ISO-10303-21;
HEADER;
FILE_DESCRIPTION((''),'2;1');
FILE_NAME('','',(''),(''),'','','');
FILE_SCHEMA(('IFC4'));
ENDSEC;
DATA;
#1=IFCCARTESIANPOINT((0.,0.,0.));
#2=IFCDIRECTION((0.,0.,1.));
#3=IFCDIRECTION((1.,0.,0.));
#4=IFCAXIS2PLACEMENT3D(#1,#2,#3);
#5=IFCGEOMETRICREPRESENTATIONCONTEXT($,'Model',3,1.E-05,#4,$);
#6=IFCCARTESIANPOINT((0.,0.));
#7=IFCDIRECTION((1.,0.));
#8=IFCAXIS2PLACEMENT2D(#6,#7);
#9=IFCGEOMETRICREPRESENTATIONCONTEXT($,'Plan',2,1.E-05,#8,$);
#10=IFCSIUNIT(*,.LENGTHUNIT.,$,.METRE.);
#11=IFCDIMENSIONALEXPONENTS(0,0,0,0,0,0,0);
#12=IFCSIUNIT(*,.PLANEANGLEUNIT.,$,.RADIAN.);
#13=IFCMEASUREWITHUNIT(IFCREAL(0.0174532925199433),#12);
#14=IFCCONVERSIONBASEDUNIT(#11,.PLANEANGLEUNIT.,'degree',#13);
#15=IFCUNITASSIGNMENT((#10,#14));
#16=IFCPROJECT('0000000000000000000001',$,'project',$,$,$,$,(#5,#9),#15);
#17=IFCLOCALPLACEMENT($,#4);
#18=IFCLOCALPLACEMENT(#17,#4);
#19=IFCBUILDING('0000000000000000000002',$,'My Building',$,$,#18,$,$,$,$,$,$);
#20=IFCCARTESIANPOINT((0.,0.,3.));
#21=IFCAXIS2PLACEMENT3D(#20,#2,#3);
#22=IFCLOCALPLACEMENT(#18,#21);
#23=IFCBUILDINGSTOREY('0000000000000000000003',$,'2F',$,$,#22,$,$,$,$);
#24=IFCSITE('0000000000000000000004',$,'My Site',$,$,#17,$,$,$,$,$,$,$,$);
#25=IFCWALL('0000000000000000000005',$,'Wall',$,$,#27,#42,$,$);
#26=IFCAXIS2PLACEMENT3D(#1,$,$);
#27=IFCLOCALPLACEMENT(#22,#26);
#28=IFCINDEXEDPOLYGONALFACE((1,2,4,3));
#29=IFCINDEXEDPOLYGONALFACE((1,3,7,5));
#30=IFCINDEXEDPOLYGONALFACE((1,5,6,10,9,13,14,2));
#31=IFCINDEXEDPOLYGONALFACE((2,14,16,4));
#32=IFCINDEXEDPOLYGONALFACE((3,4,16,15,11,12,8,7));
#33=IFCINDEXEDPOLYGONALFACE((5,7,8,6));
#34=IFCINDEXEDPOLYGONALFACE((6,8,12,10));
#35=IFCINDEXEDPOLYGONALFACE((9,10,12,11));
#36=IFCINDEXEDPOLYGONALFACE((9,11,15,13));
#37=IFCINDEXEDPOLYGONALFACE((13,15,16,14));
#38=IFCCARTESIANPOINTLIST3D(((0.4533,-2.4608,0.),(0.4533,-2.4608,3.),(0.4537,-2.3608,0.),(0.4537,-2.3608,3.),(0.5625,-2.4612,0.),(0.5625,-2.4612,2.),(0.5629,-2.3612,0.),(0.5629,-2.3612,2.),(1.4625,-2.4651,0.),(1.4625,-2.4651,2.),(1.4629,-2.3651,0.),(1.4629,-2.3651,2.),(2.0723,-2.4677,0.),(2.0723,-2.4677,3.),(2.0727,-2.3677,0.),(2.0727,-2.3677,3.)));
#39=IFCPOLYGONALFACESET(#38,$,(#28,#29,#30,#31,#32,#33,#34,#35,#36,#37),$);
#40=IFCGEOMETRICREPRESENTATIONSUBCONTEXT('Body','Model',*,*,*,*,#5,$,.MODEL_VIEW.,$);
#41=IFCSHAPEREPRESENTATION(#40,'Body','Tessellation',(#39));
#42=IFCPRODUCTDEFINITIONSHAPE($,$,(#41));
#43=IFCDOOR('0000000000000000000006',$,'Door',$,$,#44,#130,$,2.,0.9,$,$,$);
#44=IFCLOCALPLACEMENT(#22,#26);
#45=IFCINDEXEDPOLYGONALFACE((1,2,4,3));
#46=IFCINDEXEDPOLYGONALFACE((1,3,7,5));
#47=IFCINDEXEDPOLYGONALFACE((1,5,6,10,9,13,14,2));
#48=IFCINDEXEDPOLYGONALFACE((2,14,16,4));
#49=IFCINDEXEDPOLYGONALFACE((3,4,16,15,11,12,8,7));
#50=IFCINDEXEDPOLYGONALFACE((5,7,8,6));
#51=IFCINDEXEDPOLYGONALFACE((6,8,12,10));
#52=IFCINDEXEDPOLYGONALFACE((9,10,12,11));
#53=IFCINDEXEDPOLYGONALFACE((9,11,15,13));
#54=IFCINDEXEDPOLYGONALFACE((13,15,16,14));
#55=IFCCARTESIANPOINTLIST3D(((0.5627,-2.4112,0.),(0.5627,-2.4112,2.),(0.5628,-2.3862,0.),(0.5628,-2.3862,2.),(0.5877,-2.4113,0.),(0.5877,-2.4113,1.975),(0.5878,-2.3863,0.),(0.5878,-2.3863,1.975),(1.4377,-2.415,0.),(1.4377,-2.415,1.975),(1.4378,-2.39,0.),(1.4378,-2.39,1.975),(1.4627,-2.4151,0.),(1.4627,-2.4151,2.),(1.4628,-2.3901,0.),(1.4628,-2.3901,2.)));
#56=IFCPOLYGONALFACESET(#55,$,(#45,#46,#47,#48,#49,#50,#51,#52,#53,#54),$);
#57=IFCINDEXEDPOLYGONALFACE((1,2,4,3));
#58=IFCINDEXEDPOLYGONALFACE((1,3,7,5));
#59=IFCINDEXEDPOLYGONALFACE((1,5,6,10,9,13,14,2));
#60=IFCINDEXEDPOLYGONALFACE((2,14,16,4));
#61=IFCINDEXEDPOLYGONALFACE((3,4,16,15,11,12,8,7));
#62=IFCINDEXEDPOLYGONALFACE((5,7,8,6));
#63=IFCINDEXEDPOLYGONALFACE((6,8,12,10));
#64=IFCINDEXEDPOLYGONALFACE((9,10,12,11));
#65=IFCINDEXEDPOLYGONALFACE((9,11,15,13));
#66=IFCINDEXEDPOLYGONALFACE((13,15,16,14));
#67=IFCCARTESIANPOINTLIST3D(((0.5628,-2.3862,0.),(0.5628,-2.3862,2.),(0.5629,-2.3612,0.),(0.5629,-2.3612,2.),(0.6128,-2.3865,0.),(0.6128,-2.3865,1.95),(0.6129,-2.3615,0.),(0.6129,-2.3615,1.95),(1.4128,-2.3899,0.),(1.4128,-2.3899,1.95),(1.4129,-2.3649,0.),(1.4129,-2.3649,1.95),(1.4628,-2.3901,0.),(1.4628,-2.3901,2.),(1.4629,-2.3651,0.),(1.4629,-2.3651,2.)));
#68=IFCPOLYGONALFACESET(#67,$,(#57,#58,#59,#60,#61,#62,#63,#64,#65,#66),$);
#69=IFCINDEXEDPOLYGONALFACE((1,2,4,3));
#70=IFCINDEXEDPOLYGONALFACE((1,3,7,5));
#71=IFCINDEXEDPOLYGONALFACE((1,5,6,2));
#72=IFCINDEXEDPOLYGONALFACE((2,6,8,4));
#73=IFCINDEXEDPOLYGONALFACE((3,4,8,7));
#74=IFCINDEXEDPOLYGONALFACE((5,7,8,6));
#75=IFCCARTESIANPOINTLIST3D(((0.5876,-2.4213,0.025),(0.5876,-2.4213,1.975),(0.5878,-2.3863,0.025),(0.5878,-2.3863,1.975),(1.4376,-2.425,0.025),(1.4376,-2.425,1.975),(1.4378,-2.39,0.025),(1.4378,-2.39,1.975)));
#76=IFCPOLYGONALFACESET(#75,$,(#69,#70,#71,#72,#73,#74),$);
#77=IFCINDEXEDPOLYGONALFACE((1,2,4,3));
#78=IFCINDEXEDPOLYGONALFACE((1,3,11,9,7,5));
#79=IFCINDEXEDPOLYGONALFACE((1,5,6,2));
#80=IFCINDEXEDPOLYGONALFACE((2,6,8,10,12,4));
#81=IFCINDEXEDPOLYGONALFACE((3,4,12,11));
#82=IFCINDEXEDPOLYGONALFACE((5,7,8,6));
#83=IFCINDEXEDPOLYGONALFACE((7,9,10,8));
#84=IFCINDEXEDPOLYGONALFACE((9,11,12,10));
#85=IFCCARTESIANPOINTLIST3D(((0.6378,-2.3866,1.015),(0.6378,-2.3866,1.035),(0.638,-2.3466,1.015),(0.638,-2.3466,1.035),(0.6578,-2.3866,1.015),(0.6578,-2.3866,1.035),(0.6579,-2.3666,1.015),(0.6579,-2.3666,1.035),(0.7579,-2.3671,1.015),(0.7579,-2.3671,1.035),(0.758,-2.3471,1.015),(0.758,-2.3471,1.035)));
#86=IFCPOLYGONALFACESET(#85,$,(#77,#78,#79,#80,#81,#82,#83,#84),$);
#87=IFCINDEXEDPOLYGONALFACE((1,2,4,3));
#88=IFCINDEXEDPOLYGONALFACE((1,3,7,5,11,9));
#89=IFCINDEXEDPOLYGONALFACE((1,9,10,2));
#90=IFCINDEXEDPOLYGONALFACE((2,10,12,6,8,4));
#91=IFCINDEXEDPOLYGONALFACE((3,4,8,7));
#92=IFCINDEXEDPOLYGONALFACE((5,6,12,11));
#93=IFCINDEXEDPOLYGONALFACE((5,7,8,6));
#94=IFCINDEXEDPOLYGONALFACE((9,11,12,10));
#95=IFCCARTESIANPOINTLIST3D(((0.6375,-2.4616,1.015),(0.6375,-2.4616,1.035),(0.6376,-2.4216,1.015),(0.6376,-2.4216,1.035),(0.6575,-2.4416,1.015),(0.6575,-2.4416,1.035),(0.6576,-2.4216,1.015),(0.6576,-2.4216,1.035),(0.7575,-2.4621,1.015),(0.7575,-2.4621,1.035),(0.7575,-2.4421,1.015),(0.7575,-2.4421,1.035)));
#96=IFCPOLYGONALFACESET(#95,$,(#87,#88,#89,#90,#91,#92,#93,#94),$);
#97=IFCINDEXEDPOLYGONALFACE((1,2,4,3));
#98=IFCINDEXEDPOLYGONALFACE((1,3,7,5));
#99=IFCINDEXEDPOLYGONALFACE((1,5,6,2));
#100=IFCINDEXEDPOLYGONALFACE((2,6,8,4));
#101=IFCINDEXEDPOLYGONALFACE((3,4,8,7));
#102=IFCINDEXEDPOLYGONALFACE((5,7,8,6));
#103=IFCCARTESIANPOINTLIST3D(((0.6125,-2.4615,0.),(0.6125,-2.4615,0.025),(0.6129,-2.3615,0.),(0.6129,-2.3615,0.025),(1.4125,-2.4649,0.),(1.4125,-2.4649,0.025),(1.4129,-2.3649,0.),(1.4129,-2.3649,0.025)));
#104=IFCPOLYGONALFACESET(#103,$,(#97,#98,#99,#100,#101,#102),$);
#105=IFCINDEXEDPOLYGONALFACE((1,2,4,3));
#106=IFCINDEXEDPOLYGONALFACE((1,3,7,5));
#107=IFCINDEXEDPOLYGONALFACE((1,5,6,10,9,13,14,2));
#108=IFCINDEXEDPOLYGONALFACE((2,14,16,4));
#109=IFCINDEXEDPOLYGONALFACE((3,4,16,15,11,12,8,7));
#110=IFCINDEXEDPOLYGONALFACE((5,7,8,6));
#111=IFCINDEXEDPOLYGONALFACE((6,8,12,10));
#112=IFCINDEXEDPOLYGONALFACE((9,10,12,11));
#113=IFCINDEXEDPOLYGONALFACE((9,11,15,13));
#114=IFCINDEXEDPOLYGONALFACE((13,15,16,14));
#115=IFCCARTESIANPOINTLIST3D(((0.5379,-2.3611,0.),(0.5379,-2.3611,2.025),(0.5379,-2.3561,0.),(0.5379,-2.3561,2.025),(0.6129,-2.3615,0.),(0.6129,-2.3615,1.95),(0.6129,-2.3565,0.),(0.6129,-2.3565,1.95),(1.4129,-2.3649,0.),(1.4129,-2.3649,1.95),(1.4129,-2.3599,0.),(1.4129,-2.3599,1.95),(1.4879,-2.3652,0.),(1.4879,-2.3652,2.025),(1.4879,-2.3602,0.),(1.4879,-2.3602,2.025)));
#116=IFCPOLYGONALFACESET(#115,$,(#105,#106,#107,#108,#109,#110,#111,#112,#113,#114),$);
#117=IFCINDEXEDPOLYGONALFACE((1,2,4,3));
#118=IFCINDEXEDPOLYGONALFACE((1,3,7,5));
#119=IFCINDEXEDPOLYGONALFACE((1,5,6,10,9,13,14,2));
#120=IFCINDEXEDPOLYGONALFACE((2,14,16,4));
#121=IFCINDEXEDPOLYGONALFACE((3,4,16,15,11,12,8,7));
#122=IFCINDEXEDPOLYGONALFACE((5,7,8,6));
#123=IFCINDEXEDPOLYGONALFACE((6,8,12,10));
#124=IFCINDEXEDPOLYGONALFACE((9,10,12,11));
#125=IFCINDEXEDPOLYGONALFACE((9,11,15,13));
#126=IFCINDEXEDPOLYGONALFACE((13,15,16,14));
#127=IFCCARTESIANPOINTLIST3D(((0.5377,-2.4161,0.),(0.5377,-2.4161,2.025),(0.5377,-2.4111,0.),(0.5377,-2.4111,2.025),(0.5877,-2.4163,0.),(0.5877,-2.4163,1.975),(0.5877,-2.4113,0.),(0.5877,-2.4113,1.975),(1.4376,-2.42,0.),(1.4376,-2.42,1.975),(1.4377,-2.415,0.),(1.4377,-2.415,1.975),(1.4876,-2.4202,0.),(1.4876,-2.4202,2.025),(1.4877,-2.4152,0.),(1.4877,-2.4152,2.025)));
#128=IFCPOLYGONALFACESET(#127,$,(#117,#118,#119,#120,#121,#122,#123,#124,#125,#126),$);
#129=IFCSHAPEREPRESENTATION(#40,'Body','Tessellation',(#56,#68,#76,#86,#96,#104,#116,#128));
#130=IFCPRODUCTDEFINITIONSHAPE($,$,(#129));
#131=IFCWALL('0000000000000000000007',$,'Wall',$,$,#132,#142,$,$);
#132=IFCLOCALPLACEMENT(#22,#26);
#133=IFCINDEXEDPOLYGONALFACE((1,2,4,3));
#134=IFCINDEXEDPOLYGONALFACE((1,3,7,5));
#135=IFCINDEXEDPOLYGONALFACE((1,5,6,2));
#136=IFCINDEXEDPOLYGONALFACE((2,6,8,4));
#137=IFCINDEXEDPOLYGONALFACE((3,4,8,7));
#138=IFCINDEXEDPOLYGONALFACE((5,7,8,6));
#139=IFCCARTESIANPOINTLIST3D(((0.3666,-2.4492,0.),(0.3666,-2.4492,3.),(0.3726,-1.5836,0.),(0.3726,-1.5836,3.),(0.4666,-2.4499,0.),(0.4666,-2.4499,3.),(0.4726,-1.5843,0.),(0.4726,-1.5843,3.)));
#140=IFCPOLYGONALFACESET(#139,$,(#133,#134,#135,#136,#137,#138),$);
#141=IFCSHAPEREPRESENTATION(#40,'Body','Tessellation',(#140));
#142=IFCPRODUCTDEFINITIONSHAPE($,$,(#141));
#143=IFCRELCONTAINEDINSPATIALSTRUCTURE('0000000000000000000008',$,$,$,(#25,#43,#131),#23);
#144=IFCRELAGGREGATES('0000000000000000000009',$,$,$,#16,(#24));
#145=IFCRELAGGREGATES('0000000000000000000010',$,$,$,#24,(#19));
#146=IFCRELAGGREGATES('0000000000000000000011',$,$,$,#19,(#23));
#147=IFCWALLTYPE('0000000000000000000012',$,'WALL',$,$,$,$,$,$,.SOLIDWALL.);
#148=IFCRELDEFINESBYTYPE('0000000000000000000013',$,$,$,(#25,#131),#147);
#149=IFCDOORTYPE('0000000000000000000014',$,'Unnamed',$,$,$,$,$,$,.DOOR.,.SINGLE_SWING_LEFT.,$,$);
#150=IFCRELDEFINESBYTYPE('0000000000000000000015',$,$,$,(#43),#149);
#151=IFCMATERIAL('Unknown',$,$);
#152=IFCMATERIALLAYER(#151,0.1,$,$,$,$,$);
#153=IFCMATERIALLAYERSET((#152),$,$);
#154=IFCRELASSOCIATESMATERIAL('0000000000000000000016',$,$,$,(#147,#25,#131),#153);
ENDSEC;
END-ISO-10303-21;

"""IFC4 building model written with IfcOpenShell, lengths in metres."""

from ifc_helpers import new_model, entity, si_unit, converted_unit, frame, origin_with_axes, origin_2d_with_axis, place, context, subcontext, project, spatial, line, indexed_curve, outline, extrude, shape, source, transform, mapped, material, layer, layer_set, layer_usage, type_object, type_shapes, element, fill, save


model = new_model("IFC4")

# Units and contexts
model_context = context("Model", 3, precision=1e-05, world=origin_with_axes())
plan_context = context("Plan", 2, precision=1e-05, world=origin_2d_with_axis())
body_context_1 = subcontext(model_context, "Body", "Model", "MODEL_VIEW")
body_context_2 = subcontext(plan_context, "Body", "Plan", "PLAN_VIEW")
ifc_project = project(units=[si_unit("LENGTHUNIT", "METRE"), converted_unit("PLANEANGLEUNIT", "degree", entity("IfcReal", 0.0174532925199433), si_unit("PLANEANGLEUNIT", "RADIAN"), dimensions=[0, 0, 0, 0, 0, 0, 0])], contexts=[model_context, plan_context])

# Site, building, storey
site_placement = place(None, origin_with_axes())
site = spatial("IfcSite", under=ifc_project, at=site_placement, Name="My Site")
building_placement = place(site_placement, origin_with_axes())
building = spatial("IfcBuilding", under=site, at=building_placement, Name="My Building")
storey_placement = place(building_placement, frame((0.0, 0.0, 3.0), z_axis=(0.0, 0.0, 1.0), x_axis=(1.0, 0.0, 0.0)))
storey = spatial("IfcBuildingStorey", under=building, at=storey_placement, Name="2F")

# Shared definitions
ifc_material = material(Name="Unknown")
ifc_layer = layer(ifc_material, 0.1)
ifc_layer_set = layer_set([ifc_layer])
wall_type = type_object("IfcWallType", Name="WALL", PredefinedType="SOLIDWALL", material=ifc_layer_set)

# Shared definitions
shared_shape_1 = source(origin_with_axes(), body_context_1, "Body", "SweptSolid", [
    extrude(outline(indexed_curve([(0.0, 0.0), (0.9, 0.0), (0.9, 2.0), (0.0, 2.0)], segments=[line(1, 2, 3, 4, 1)])), frame((0.0, -0.6, 0.0), z_axis=(0.0, -1.0, 0.0), x_axis=(1.0, 0.0, 0.0)), (0.0, 0.0, -1.0), 1.2),
])
door_type = type_object("IfcDoorType", Name="Unnamed", OperationType="SINGLE_SWING_LEFT", PredefinedType="DOOR")
shared_shape_2 = source(origin_with_axes(), body_context_1, "Body", "SweptSolid", [
    extrude(outline(indexed_curve([(0.0, 0.0), (0.0, 2.0), (0.9, 2.0), (0.9, 0.0), (0.875, 0.0), (0.875, 1.975), (0.025, 1.975), (0.025, 0.0)], segments=[line(1, 2, 3, 4, 5, 6, 7, 8, 1)])), frame((0.0, 0.025, 0.0), z_axis=(0.0, -1.0, 0.0), x_axis=(1.0, 0.0, 0.0)), (0.0, 0.0, -1.0), 0.025),
    extrude(outline(indexed_curve([(0.0, 0.0), (0.0, 2.0), (0.9, 2.0), (0.9, 0.0), (0.85, 0.0), (0.85, 1.95), (0.05, 1.95), (0.05, 0.0)], segments=[line(1, 2, 3, 4, 5, 6, 7, 8, 1)])), frame((0.0, 0.0, 0.0), z_axis=(0.0, -1.0, 0.0), x_axis=(1.0, 0.0, 0.0)), (0.0, 0.0, -1.0), 0.025),
    extrude(outline(indexed_curve([(0.0, 0.0), (0.85, 0.0), (0.85, 0.035), (0.0, 0.035)], segments=[line(1, 2, 3, 4, 1)])), frame((0.025, 0.025, 0.025), z_axis=(0.0, 0.0, 1.0), x_axis=(1.0, 0.0, 0.0)), (0.0, 0.0, 1.0), 1.95),
    extrude(outline(indexed_curve([(0.0, 0.0), (0.0, -0.04), (-0.12, -0.04), (-0.12, -0.02), (-0.02, -0.02), (-0.02, 0.0)], segments=[line(1, 2, 3, 4, 5, 6, 1)])), frame((0.825, 0.025, 1.015), z_axis=(0.0, 0.0, 1.0), x_axis=(1.0, 0.0, 0.0)), (0.0, 0.0, 1.0), 0.02),
    extrude(outline(indexed_curve([(0.0, 0.0), (0.0, 0.04), (-0.12, 0.04), (-0.12, 0.02), (-0.02, 0.02), (-0.02, 0.0)], segments=[line(1, 2, 3, 4, 5, 6, 1)])), frame((0.825, 0.06, 1.015), z_axis=(0.0, 0.0, 1.0), x_axis=(1.0, 0.0, 0.0)), (0.0, 0.0, 1.0), 0.02),
    extrude(outline(indexed_curve([(0.0, 0.0), (0.8, 0.0), (0.8, 0.1), (0.0, 0.1)], segments=[line(1, 2, 3, 4, 1)])), frame((0.05, 0.0, 0.0), z_axis=(0.0, 0.0, 1.0), x_axis=(1.0, 0.0, 0.0)), (0.0, 0.0, 1.0), 0.025),
    extrude(outline(indexed_curve([(0.0, 0.0), (0.0, 2.025), (0.95, 2.025), (0.95, 0.0), (0.875, 0.0), (0.875, 1.95), (0.075, 1.95), (0.075, 0.0)], segments=[line(1, 2, 3, 4, 5, 6, 7, 8, 1)])), frame((-0.025, -0.005, 0.0), z_axis=(0.0, -1.0, 0.0), x_axis=(1.0, 0.0, 0.0)), (0.0, 0.0, -1.0), 0.005),
    extrude(outline(indexed_curve([(0.0, 0.0), (0.0, 2.025), (0.95, 2.025), (0.95, 0.0), (0.9, 0.0), (0.9, 1.975), (0.05, 1.975), (0.05, 0.0)], segments=[line(1, 2, 3, 4, 5, 6, 7, 8, 1)])), frame((-0.025, 0.05, 0.0), z_axis=(0.0, -1.0, 0.0), x_axis=(1.0, 0.0, 0.0)), (0.0, 0.0, -1.0), 0.005),
])
shared_shape_3 = source(origin_with_axes(), body_context_2, "Body", "Curve2D", [
    entity("IfcIndexedPolyCurve", entity("IfcCartesianPointList2D", [[0.0, 0.0], [0.0, 0.05], [0.025, 0.05], [0.025, 0.025], [0.05, 0.025], [0.05, 0.0]]), [entity("IfcLineIndex", [1, 2, 3, 4, 5, 6, 1])]),
    entity("IfcIndexedPolyCurve", entity("IfcCartesianPointList2D", [[0.9, 0.0], [0.9, 0.05], [0.875, 0.05], [0.875, 0.025], [0.85, 0.025], [0.85, 0.0]]), [entity("IfcLineIndex", [1, 2, 3, 4, 5, 6, 1])]),
    entity("IfcTrimmedCurve", entity("IfcEllipse", entity("IfcAxis2Placement2D", entity("IfcCartesianPoint", [0.06, 0.05]), entity("IfcDirection", [1.0, 0.0])), 0.815, 0.85), [entity("IfcCartesianPoint", [0.875, 0.05])], [entity("IfcCartesianPoint", [0.06, 0.9])], True, "CARTESIAN"),
    entity("IfcIndexedPolyCurve", entity("IfcCartesianPointList2D", [[0.025, 0.05], [0.06, 0.05], [0.06, 0.9], [0.025, 0.9]]), [entity("IfcLineIndex", [1, 2, 3, 4, 1])]),
])
type_shapes(door_type, [shared_shape_2, shared_shape_3])

# Wall, opening, door
ifc_layer_usage_1 = layer_usage(ifc_layer_set, "AXIS2", "POSITIVE", 0.0)
wall_1_placement = place(storey_placement, frame((2.0727, -2.3677, 0.0), z_axis=(0.0, 0.0, 1.0), x_axis=(-0.999991, 0.00431, 0.0)))
wall_1 = element("IfcWall", 1, at=wall_1_placement, inside=storey, type_object=wall_type, material=ifc_layer_usage_1, Name="Wall", context=body_context_1, shape_type="SweptSolid", body=[
    extrude(outline(indexed_curve([(0.0, 0.0), (0.0, 0.1), (1.619, 0.1), (1.619, 0.0)], segments=[line(1, 2, 3, 4, 1)])), origin_with_axes(), (0.0, 0.0, 1.0), 3.0),
])
opening_1_placement = place(wall_1_placement, frame((0.6098, 0.0, 0.0), z_axis=(0.0, 0.0, 1.0), x_axis=(1.0, 0.0, 0.0)))
opening_1 = element("IfcOpeningElement", 2, at=opening_1_placement, cuts=wall_1, PredefinedType="OPENING", context=body_context_1, shape_type="MappedRepresentation", body=[
    mapped(shared_shape_1, transform((0.0, 0.0, 0.0), x_axis=(1.0, 0.0, 0.0), y_axis=(0.0, 1.0, 0.0), z_axis=(0.0, 0.0, 1.0), scale=1.0)),
])
door_1_placement = place(opening_1_placement, frame((0.0, 0.0, 0.0), z_axis=(0.0, 0.0, 1.0), x_axis=(1.0, 0.0, 0.0)))
door_1 = element("IfcDoor", 3, at=door_1_placement, inside=storey, type_object=door_type, Name="Door", OverallHeight=2.0, OverallWidth=0.9, shapes=[
    shape(body_context_1, "Body", "MappedRepresentation", [mapped(shared_shape_2, transform((0.0, 0.0, 0.0), x_axis=(1.0, 0.0, 0.0), y_axis=(0.0, 1.0, 0.0), z_axis=(0.0, 0.0, 1.0), scale=1.0))]),
    shape(body_context_2, "Body", "MappedRepresentation", [mapped(shared_shape_3, transform((0.0, 0.0, 0.0), x_axis=(1.0, 0.0, 0.0), y_axis=(0.0, 1.0, 0.0), z_axis=(0.0, 0.0, 1.0), scale=1.0))]),
])
fill(opening_1, door_1)

# Wall
ifc_layer_usage_2 = layer_usage(ifc_layer_set, "AXIS2", "POSITIVE", 0.0)
wall_2_placement = place(storey_placement, frame((0.3726, -1.5836, 0.0), z_axis=(0.0, 0.0, 1.0), x_axis=(-0.006993, -0.999976, 0.0)))
element("IfcWall", 4, at=wall_2_placement, inside=storey, type_object=wall_type, material=ifc_layer_usage_2, Name="Wall", context=body_context_1, shape_type="SweptSolid", body=[
    extrude(outline(indexed_curve([(0.0, 0.0), (0.0, 0.1), (0.8656, 0.1), (0.8656, 0.0)], segments=[line(1, 2, 3, 4, 1)])), origin_with_axes(), (0.0, 0.0, 1.0), 3.0),
])

save(model, "model.ifc")
